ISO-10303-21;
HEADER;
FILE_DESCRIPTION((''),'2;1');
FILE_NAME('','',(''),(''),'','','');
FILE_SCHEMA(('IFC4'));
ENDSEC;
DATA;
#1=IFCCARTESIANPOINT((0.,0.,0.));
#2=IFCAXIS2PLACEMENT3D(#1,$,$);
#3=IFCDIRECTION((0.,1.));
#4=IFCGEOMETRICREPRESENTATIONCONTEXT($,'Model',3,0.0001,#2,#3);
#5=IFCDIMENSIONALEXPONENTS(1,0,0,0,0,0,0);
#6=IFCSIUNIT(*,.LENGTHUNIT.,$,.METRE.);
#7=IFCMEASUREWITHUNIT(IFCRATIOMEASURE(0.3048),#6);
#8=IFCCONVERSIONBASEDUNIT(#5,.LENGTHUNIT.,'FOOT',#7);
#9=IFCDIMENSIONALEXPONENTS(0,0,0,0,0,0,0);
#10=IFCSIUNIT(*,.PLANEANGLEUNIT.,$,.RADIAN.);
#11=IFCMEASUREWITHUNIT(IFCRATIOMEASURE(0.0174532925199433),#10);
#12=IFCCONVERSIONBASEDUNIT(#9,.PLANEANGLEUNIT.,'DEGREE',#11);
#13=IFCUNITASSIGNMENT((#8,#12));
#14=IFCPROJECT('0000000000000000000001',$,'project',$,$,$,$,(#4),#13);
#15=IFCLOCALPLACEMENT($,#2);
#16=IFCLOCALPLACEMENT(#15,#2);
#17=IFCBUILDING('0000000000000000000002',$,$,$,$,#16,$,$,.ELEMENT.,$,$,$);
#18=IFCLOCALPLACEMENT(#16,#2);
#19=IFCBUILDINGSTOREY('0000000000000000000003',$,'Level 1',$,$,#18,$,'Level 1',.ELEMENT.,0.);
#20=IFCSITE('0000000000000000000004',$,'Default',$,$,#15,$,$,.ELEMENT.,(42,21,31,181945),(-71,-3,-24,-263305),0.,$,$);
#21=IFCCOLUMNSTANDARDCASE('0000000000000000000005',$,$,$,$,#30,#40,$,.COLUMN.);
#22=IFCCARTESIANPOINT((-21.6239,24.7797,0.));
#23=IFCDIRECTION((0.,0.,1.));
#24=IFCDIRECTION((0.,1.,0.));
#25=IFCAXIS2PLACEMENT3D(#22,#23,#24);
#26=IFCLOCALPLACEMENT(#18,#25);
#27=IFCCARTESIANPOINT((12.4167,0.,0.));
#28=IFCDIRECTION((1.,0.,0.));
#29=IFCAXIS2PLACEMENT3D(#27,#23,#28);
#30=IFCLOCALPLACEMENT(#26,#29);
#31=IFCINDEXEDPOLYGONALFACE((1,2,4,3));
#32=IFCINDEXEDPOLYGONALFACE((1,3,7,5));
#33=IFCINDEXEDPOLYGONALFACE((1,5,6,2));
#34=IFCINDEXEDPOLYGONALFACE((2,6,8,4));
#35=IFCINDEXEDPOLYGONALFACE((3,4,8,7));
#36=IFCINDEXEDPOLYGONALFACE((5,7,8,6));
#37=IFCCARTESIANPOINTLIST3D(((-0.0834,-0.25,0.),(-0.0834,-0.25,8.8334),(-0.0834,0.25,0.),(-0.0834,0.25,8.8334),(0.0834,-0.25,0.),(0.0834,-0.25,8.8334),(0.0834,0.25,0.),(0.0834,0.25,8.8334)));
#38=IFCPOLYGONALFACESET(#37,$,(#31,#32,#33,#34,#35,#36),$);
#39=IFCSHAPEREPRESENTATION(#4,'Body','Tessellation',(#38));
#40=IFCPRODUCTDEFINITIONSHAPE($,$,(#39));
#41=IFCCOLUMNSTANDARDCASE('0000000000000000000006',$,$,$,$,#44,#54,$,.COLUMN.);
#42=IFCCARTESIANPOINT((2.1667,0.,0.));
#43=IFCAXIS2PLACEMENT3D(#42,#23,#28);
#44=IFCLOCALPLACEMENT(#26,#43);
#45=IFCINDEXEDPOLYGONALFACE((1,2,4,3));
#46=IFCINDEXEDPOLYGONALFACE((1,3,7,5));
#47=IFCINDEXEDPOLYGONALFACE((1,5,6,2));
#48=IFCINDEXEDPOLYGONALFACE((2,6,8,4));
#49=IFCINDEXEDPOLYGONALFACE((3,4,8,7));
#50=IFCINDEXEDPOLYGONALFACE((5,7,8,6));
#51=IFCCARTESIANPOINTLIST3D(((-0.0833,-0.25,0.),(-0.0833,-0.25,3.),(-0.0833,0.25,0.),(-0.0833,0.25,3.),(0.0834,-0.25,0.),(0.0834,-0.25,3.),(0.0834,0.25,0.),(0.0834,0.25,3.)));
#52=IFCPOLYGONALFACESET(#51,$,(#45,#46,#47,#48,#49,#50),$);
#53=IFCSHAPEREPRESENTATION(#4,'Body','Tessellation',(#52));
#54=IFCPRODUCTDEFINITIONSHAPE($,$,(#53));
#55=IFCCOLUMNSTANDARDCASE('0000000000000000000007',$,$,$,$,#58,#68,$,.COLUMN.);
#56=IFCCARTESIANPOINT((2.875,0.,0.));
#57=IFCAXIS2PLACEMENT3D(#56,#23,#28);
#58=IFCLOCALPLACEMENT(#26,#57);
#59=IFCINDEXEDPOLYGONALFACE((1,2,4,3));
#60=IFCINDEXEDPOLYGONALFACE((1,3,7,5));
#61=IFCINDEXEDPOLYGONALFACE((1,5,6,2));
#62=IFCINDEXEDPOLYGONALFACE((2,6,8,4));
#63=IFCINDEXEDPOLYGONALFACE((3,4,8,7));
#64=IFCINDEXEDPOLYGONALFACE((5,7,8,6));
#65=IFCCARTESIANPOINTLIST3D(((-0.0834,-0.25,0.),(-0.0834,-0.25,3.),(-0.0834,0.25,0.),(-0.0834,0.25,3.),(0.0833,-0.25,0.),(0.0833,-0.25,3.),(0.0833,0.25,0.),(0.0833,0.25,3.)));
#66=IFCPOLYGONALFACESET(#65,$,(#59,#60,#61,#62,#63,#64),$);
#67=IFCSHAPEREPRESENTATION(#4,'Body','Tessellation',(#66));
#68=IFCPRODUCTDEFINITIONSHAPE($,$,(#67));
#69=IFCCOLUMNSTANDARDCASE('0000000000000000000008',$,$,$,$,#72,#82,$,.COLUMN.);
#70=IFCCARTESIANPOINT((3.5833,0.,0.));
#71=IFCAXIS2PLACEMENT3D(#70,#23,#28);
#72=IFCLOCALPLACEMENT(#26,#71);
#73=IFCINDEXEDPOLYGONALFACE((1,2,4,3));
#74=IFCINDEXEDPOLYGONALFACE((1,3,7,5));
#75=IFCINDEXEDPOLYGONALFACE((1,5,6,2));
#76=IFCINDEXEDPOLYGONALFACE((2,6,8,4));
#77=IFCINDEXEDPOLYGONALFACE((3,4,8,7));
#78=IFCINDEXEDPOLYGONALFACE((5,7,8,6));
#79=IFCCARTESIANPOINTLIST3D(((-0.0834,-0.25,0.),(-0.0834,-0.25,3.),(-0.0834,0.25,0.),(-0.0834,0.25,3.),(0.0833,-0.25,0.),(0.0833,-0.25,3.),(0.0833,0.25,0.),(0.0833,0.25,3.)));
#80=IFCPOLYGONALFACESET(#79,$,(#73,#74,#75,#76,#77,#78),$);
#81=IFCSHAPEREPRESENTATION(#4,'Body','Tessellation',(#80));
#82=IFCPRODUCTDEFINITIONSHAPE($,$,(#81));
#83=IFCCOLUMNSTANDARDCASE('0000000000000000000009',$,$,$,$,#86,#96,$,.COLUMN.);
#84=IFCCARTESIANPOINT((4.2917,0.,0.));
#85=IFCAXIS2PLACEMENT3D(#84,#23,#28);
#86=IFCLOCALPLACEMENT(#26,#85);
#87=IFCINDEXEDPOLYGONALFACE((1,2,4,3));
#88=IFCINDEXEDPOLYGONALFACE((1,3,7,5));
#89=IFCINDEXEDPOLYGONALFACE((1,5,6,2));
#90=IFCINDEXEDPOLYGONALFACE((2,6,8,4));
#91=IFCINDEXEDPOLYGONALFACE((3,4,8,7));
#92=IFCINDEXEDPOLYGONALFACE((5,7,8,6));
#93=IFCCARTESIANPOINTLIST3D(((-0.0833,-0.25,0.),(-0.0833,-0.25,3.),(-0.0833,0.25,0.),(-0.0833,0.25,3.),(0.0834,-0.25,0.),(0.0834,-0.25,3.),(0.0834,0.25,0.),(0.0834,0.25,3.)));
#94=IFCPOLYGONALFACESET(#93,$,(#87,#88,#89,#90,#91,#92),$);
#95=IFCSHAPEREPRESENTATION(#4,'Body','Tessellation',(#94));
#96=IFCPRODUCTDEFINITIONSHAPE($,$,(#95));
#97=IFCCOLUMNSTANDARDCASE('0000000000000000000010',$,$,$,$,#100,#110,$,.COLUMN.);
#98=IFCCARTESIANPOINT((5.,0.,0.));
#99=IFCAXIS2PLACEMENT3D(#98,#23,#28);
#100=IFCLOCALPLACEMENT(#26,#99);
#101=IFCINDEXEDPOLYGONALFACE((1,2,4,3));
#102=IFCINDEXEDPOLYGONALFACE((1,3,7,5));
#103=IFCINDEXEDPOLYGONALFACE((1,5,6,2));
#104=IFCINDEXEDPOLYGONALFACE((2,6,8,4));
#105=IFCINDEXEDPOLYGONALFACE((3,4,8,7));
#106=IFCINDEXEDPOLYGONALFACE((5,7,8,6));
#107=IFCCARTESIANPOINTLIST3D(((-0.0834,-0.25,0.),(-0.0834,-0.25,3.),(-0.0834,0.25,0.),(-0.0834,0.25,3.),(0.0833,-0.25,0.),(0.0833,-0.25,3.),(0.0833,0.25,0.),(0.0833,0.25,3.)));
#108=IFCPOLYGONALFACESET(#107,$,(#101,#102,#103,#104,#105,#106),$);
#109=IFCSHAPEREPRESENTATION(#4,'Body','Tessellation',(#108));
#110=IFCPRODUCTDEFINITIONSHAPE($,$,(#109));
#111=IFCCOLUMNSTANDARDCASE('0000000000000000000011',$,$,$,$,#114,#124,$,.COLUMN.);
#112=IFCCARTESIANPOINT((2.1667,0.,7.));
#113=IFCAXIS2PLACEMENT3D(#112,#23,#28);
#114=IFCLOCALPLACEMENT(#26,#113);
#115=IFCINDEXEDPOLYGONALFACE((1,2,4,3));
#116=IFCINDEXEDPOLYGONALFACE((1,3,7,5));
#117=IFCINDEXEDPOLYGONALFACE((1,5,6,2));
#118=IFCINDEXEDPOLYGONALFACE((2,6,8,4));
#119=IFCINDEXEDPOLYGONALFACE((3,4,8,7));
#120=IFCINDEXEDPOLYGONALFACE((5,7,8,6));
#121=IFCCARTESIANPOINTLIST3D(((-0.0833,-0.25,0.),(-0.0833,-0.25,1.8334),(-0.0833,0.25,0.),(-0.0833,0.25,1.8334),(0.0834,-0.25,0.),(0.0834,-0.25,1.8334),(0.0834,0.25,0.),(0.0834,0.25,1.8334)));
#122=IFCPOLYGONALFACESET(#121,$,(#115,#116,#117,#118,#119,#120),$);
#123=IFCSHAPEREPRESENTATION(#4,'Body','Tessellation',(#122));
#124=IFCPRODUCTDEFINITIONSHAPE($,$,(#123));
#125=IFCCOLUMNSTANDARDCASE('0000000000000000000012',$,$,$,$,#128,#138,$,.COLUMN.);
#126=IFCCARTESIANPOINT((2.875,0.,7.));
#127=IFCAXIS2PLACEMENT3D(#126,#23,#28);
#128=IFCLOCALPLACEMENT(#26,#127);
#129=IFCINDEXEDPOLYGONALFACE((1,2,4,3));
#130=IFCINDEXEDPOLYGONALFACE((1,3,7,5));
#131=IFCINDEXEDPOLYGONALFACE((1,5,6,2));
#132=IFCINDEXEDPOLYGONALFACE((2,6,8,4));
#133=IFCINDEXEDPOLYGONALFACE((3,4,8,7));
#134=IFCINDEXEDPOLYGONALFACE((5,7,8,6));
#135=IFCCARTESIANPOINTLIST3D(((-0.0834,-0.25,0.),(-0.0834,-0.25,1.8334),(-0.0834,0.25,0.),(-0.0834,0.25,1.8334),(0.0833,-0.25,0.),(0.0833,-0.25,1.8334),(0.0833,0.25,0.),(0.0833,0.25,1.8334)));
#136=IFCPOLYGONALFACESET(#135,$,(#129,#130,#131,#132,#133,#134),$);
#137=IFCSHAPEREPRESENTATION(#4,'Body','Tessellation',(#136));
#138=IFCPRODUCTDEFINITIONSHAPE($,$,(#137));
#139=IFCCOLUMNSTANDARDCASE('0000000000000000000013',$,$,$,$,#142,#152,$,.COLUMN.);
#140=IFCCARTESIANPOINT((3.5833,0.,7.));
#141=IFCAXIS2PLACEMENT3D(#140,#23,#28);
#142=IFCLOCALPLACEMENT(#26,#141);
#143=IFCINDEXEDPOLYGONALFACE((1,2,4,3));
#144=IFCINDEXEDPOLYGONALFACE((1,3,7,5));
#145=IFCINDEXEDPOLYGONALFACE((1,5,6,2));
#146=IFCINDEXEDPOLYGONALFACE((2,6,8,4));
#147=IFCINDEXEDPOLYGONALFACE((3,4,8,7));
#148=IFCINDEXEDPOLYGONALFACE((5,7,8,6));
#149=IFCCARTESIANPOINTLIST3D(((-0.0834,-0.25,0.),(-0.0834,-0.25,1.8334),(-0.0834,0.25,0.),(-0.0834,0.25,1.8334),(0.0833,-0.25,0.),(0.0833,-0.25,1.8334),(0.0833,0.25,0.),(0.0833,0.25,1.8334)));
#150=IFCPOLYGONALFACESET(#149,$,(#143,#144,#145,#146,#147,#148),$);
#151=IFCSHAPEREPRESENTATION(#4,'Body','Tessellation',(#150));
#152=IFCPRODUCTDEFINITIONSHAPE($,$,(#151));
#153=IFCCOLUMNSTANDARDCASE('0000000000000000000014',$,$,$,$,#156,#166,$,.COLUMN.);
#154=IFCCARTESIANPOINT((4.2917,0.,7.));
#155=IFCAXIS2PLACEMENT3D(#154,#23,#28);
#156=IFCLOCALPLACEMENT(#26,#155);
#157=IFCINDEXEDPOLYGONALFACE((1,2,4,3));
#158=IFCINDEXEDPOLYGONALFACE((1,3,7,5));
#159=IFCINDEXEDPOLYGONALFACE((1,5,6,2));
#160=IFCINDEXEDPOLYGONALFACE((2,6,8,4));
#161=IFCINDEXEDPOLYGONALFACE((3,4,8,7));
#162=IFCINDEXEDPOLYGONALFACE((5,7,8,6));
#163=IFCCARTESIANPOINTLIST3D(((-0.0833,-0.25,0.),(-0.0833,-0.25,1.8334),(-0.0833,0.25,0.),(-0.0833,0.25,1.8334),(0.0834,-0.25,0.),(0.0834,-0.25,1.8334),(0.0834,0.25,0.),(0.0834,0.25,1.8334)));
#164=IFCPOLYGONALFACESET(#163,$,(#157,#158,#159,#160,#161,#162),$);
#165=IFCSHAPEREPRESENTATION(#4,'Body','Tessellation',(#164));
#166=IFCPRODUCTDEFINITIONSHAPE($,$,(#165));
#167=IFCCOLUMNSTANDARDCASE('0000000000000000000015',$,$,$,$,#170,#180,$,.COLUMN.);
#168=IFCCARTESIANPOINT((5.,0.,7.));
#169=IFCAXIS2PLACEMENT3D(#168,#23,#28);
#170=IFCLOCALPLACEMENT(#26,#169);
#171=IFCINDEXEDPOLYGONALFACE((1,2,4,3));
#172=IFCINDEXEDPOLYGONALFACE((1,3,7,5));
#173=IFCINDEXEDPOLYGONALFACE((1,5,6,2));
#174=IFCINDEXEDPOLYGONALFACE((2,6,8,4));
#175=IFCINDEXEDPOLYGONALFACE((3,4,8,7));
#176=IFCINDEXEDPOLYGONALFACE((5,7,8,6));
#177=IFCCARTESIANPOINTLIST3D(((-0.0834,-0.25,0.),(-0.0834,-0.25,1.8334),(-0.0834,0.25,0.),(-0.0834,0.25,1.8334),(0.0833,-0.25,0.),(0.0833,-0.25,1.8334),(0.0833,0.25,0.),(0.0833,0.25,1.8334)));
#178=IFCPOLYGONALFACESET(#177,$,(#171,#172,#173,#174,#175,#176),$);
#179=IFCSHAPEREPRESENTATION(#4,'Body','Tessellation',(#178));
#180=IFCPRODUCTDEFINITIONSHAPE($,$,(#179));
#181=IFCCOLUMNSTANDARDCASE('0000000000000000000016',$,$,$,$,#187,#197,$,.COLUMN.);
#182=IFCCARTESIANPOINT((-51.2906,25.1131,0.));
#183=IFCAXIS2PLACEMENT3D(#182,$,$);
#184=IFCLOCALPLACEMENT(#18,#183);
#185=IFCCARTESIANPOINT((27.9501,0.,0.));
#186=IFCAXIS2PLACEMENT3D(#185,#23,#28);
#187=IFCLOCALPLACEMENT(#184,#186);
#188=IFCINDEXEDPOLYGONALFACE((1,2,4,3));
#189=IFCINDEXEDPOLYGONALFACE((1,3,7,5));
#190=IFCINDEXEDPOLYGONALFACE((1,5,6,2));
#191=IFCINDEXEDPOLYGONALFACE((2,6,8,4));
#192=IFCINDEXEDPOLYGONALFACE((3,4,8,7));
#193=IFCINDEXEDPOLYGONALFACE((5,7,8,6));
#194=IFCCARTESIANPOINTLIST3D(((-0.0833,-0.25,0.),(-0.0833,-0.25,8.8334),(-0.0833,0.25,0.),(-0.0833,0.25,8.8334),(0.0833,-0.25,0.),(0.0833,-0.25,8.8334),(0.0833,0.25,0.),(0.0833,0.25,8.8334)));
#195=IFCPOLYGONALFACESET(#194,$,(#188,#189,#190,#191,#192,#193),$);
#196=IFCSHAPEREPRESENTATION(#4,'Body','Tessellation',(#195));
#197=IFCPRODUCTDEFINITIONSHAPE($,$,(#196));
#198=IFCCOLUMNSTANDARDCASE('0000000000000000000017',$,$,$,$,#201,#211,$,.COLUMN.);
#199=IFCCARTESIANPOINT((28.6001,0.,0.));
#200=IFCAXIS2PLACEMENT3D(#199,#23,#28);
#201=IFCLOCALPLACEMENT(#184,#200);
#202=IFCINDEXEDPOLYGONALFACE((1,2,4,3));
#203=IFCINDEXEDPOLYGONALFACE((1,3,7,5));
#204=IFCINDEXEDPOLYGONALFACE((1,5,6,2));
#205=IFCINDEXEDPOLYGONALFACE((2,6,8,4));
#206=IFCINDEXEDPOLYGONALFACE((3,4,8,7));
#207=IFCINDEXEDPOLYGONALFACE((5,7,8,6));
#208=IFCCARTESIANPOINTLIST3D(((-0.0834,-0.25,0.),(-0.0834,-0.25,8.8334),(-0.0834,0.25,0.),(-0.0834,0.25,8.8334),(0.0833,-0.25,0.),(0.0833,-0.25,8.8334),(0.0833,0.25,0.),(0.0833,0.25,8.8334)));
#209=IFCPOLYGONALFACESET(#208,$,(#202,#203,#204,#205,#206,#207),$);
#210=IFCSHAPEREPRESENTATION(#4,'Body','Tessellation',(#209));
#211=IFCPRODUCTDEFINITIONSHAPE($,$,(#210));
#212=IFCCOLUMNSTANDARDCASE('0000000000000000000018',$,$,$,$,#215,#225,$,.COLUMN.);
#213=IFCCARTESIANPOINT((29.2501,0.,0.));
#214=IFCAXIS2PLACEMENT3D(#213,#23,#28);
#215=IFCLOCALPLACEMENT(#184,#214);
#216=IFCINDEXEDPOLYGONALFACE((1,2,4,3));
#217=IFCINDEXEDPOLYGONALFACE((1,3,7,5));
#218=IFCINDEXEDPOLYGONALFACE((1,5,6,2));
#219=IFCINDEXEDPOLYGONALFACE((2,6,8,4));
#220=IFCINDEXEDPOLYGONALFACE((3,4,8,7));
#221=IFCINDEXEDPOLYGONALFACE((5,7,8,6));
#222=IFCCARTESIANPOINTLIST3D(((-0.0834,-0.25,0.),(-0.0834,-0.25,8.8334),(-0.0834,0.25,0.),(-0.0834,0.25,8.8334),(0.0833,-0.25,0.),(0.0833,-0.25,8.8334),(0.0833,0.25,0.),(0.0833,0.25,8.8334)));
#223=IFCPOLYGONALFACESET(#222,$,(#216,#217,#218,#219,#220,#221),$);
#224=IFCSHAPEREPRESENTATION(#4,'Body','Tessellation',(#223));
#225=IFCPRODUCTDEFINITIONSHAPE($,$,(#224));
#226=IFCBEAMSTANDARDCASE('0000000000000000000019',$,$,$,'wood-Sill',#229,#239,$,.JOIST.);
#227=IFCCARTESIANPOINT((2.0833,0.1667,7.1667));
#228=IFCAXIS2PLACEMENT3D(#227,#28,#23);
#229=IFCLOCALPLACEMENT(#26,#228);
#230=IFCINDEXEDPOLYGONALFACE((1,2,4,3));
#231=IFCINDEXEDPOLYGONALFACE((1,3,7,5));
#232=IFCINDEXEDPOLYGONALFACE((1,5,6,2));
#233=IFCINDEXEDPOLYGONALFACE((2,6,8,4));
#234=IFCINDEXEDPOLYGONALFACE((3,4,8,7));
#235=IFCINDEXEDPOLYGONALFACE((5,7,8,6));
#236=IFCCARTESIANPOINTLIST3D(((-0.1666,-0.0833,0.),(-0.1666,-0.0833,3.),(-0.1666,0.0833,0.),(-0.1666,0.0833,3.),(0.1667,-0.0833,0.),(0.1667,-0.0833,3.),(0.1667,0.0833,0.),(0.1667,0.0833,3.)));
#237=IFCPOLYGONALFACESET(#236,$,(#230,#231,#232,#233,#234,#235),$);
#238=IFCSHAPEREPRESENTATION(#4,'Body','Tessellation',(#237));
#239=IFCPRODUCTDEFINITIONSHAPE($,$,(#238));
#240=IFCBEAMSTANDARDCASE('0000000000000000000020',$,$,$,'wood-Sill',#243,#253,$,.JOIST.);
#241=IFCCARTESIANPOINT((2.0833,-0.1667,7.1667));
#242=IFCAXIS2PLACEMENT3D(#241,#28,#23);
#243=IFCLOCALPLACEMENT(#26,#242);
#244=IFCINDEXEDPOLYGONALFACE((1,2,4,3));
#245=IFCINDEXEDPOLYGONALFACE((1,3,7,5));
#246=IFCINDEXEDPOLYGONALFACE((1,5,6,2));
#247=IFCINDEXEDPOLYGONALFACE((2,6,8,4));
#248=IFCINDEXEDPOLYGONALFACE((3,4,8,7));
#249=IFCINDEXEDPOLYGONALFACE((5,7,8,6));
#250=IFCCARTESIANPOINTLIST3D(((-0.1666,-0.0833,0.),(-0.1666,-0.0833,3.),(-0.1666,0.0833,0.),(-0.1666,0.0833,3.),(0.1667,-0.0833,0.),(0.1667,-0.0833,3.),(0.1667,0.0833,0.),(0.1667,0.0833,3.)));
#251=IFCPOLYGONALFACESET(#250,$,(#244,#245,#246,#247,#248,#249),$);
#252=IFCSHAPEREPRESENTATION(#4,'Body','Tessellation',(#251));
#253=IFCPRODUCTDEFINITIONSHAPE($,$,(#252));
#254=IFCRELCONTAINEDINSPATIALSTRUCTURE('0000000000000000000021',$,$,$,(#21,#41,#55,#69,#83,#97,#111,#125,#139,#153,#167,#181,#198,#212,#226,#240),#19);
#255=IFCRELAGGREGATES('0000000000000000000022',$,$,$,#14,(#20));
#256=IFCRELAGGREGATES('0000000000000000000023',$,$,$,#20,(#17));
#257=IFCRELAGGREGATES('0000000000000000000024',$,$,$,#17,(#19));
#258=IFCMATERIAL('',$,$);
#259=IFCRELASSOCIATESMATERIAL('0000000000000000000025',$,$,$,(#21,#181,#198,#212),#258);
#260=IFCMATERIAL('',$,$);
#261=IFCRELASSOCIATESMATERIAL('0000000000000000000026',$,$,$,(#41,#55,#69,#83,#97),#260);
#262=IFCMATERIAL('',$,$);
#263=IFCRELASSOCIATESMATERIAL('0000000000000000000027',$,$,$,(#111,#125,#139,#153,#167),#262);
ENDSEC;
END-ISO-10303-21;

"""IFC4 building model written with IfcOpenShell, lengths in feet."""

from ifc_helpers import new_model, entity, si_unit, converted_unit, direction, frame, origin, origin_with_axes, place, context, project, spatial, rectangle, extrude, material, element, save


model = new_model("IFC4")

# Units and contexts
model_context = context("Model", 3, precision=0.0001, world=origin(), true_north=direction((0.0, 1.0)))
ifc_project = project(units=[converted_unit("LENGTHUNIT", "FOOT", entity("IfcRatioMeasure", 0.3048), si_unit("LENGTHUNIT", "METRE"), dimensions=[1, 0, 0, 0, 0, 0, 0]), converted_unit("PLANEANGLEUNIT", "DEGREE", entity("IfcRatioMeasure", 0.0174532925199433), si_unit("PLANEANGLEUNIT", "RADIAN"), dimensions=[0, 0, 0, 0, 0, 0, 0])], contexts=[model_context])

# Site, building, storey
site_placement = place(None, origin())
site = spatial("IfcSite", under=ifc_project, at=site_placement, Name="Default", CompositionType="ELEMENT", RefLatitude=(42, 21, 31, 181945), RefLongitude=(-71, -3, -24, -263305), RefElevation=0.0)
building_placement = place(site_placement, origin())
building = spatial("IfcBuilding", under=site, at=building_placement, CompositionType="ELEMENT")
storey_placement = place(building_placement, origin())
storey = spatial("IfcBuildingStorey", under=building, at=storey_placement, Name="Level 1", LongName="Level 1", CompositionType="ELEMENT", Elevation=0.0)

# Columns
placement_1 = place(storey_placement, frame((-21.6239, 24.7797, 0.0), z_axis=(0.0, 0.0, 1.0), x_axis=(0.0, 1.0, 0.0)))
ifc_material_1 = material(Name="")
for number, where, z_axis, x_axis in (
    (1, (12.4167, 0.0, 0.0), (0.0, 0.0, 1.0), (1.0, 0.0, 0.0)),
):
    element("IfcColumnStandardCase", number, at=place(placement_1, frame(where, z_axis=z_axis, x_axis=x_axis)), inside=storey, material=ifc_material_1, PredefinedType="COLUMN", context=model_context, shape_type="SweptSolid", body=[
        extrude(rectangle(XDim=0.1667, YDim=0.5), origin(), (0.0, 0.0, 1.0), 8.8334),
    ])
ifc_material_2 = material(Name="")
for number, where, z_axis, x_axis in (
    (2, (2.1667, 0.0, 0.0), (0.0, 0.0, 1.0), (1.0, 0.0, 0.0)),
    (3, (2.875, 0.0, 0.0), (0.0, 0.0, 1.0), (1.0, 0.0, 0.0)),
    (4, (3.5833, 0.0, 0.0), (0.0, 0.0, 1.0), (1.0, 0.0, 0.0)),
    (5, (4.2917, 0.0, 0.0), (0.0, 0.0, 1.0), (1.0, 0.0, 0.0)),
    (6, (5.0, 0.0, 0.0), (0.0, 0.0, 1.0), (1.0, 0.0, 0.0)),
):
    element("IfcColumnStandardCase", number, at=place(placement_1, frame(where, z_axis=z_axis, x_axis=x_axis)), inside=storey, material=ifc_material_2, PredefinedType="COLUMN", context=model_context, shape_type="SweptSolid", body=[
        extrude(rectangle(XDim=0.1667, YDim=0.5), origin(), (0.0, 0.0, 1.0), 3.0),
    ])
ifc_material_3 = material(Name="")
for number, where, z_axis, x_axis in (
    (7, (2.1667, 0.0, 7.0), (0.0, 0.0, 1.0), (1.0, 0.0, 0.0)),
    (8, (2.875, 0.0, 7.0), (0.0, 0.0, 1.0), (1.0, 0.0, 0.0)),
    (9, (3.5833, 0.0, 7.0), (0.0, 0.0, 1.0), (1.0, 0.0, 0.0)),
    (10, (4.2917, 0.0, 7.0), (0.0, 0.0, 1.0), (1.0, 0.0, 0.0)),
    (11, (5.0, 0.0, 7.0), (0.0, 0.0, 1.0), (1.0, 0.0, 0.0)),
):
    element("IfcColumnStandardCase", number, at=place(placement_1, frame(where, z_axis=z_axis, x_axis=x_axis)), inside=storey, material=ifc_material_3, PredefinedType="COLUMN", context=model_context, shape_type="SweptSolid", body=[
        extrude(rectangle(XDim=0.1667, YDim=0.5), origin(), (0.0, 0.0, 1.0), 1.8334),
    ])
placement_2 = place(storey_placement, frame((-51.2906, 25.1131, 0.0)))
for number, where, z_axis, x_axis in (
    (12, (27.9501, 0.0, 0.0), (0.0, 0.0, 1.0), (1.0, 0.0, 0.0)),
    (13, (28.6001, 0.0, 0.0), (0.0, 0.0, 1.0), (1.0, 0.0, 0.0)),
    (14, (29.2501, 0.0, 0.0), (0.0, 0.0, 1.0), (1.0, 0.0, 0.0)),
):
    element("IfcColumnStandardCase", number, at=place(placement_2, frame(where, z_axis=z_axis, x_axis=x_axis)), inside=storey, material=ifc_material_1, PredefinedType="COLUMN", context=model_context, shape_type="SweptSolid", body=[
        extrude(rectangle(XDim=0.1667, YDim=0.5), origin(), (0.0, 0.0, 1.0), 8.8334),
    ])

# Beams
for number, where, z_axis, x_axis in (
    (15, (2.0833, 0.1667, 7.1667), (1.0, 0.0, 0.0), (0.0, 0.0, 1.0)),
    (16, (2.0833, -0.1667, 7.1667), (1.0, 0.0, 0.0), (0.0, 0.0, 1.0)),
):
    element("IfcBeamStandardCase", number, at=place(placement_1, frame(where, z_axis=z_axis, x_axis=x_axis)), inside=storey, ObjectType="wood-Sill", PredefinedType="JOIST", context=model_context, shape_type="SweptSolid", body=[
        extrude(rectangle(XDim=0.3333, YDim=0.1667), origin_with_axes(), (0.0, 0.0, 1.0), 3.0),
    ])

save(model, "model.ifc")
